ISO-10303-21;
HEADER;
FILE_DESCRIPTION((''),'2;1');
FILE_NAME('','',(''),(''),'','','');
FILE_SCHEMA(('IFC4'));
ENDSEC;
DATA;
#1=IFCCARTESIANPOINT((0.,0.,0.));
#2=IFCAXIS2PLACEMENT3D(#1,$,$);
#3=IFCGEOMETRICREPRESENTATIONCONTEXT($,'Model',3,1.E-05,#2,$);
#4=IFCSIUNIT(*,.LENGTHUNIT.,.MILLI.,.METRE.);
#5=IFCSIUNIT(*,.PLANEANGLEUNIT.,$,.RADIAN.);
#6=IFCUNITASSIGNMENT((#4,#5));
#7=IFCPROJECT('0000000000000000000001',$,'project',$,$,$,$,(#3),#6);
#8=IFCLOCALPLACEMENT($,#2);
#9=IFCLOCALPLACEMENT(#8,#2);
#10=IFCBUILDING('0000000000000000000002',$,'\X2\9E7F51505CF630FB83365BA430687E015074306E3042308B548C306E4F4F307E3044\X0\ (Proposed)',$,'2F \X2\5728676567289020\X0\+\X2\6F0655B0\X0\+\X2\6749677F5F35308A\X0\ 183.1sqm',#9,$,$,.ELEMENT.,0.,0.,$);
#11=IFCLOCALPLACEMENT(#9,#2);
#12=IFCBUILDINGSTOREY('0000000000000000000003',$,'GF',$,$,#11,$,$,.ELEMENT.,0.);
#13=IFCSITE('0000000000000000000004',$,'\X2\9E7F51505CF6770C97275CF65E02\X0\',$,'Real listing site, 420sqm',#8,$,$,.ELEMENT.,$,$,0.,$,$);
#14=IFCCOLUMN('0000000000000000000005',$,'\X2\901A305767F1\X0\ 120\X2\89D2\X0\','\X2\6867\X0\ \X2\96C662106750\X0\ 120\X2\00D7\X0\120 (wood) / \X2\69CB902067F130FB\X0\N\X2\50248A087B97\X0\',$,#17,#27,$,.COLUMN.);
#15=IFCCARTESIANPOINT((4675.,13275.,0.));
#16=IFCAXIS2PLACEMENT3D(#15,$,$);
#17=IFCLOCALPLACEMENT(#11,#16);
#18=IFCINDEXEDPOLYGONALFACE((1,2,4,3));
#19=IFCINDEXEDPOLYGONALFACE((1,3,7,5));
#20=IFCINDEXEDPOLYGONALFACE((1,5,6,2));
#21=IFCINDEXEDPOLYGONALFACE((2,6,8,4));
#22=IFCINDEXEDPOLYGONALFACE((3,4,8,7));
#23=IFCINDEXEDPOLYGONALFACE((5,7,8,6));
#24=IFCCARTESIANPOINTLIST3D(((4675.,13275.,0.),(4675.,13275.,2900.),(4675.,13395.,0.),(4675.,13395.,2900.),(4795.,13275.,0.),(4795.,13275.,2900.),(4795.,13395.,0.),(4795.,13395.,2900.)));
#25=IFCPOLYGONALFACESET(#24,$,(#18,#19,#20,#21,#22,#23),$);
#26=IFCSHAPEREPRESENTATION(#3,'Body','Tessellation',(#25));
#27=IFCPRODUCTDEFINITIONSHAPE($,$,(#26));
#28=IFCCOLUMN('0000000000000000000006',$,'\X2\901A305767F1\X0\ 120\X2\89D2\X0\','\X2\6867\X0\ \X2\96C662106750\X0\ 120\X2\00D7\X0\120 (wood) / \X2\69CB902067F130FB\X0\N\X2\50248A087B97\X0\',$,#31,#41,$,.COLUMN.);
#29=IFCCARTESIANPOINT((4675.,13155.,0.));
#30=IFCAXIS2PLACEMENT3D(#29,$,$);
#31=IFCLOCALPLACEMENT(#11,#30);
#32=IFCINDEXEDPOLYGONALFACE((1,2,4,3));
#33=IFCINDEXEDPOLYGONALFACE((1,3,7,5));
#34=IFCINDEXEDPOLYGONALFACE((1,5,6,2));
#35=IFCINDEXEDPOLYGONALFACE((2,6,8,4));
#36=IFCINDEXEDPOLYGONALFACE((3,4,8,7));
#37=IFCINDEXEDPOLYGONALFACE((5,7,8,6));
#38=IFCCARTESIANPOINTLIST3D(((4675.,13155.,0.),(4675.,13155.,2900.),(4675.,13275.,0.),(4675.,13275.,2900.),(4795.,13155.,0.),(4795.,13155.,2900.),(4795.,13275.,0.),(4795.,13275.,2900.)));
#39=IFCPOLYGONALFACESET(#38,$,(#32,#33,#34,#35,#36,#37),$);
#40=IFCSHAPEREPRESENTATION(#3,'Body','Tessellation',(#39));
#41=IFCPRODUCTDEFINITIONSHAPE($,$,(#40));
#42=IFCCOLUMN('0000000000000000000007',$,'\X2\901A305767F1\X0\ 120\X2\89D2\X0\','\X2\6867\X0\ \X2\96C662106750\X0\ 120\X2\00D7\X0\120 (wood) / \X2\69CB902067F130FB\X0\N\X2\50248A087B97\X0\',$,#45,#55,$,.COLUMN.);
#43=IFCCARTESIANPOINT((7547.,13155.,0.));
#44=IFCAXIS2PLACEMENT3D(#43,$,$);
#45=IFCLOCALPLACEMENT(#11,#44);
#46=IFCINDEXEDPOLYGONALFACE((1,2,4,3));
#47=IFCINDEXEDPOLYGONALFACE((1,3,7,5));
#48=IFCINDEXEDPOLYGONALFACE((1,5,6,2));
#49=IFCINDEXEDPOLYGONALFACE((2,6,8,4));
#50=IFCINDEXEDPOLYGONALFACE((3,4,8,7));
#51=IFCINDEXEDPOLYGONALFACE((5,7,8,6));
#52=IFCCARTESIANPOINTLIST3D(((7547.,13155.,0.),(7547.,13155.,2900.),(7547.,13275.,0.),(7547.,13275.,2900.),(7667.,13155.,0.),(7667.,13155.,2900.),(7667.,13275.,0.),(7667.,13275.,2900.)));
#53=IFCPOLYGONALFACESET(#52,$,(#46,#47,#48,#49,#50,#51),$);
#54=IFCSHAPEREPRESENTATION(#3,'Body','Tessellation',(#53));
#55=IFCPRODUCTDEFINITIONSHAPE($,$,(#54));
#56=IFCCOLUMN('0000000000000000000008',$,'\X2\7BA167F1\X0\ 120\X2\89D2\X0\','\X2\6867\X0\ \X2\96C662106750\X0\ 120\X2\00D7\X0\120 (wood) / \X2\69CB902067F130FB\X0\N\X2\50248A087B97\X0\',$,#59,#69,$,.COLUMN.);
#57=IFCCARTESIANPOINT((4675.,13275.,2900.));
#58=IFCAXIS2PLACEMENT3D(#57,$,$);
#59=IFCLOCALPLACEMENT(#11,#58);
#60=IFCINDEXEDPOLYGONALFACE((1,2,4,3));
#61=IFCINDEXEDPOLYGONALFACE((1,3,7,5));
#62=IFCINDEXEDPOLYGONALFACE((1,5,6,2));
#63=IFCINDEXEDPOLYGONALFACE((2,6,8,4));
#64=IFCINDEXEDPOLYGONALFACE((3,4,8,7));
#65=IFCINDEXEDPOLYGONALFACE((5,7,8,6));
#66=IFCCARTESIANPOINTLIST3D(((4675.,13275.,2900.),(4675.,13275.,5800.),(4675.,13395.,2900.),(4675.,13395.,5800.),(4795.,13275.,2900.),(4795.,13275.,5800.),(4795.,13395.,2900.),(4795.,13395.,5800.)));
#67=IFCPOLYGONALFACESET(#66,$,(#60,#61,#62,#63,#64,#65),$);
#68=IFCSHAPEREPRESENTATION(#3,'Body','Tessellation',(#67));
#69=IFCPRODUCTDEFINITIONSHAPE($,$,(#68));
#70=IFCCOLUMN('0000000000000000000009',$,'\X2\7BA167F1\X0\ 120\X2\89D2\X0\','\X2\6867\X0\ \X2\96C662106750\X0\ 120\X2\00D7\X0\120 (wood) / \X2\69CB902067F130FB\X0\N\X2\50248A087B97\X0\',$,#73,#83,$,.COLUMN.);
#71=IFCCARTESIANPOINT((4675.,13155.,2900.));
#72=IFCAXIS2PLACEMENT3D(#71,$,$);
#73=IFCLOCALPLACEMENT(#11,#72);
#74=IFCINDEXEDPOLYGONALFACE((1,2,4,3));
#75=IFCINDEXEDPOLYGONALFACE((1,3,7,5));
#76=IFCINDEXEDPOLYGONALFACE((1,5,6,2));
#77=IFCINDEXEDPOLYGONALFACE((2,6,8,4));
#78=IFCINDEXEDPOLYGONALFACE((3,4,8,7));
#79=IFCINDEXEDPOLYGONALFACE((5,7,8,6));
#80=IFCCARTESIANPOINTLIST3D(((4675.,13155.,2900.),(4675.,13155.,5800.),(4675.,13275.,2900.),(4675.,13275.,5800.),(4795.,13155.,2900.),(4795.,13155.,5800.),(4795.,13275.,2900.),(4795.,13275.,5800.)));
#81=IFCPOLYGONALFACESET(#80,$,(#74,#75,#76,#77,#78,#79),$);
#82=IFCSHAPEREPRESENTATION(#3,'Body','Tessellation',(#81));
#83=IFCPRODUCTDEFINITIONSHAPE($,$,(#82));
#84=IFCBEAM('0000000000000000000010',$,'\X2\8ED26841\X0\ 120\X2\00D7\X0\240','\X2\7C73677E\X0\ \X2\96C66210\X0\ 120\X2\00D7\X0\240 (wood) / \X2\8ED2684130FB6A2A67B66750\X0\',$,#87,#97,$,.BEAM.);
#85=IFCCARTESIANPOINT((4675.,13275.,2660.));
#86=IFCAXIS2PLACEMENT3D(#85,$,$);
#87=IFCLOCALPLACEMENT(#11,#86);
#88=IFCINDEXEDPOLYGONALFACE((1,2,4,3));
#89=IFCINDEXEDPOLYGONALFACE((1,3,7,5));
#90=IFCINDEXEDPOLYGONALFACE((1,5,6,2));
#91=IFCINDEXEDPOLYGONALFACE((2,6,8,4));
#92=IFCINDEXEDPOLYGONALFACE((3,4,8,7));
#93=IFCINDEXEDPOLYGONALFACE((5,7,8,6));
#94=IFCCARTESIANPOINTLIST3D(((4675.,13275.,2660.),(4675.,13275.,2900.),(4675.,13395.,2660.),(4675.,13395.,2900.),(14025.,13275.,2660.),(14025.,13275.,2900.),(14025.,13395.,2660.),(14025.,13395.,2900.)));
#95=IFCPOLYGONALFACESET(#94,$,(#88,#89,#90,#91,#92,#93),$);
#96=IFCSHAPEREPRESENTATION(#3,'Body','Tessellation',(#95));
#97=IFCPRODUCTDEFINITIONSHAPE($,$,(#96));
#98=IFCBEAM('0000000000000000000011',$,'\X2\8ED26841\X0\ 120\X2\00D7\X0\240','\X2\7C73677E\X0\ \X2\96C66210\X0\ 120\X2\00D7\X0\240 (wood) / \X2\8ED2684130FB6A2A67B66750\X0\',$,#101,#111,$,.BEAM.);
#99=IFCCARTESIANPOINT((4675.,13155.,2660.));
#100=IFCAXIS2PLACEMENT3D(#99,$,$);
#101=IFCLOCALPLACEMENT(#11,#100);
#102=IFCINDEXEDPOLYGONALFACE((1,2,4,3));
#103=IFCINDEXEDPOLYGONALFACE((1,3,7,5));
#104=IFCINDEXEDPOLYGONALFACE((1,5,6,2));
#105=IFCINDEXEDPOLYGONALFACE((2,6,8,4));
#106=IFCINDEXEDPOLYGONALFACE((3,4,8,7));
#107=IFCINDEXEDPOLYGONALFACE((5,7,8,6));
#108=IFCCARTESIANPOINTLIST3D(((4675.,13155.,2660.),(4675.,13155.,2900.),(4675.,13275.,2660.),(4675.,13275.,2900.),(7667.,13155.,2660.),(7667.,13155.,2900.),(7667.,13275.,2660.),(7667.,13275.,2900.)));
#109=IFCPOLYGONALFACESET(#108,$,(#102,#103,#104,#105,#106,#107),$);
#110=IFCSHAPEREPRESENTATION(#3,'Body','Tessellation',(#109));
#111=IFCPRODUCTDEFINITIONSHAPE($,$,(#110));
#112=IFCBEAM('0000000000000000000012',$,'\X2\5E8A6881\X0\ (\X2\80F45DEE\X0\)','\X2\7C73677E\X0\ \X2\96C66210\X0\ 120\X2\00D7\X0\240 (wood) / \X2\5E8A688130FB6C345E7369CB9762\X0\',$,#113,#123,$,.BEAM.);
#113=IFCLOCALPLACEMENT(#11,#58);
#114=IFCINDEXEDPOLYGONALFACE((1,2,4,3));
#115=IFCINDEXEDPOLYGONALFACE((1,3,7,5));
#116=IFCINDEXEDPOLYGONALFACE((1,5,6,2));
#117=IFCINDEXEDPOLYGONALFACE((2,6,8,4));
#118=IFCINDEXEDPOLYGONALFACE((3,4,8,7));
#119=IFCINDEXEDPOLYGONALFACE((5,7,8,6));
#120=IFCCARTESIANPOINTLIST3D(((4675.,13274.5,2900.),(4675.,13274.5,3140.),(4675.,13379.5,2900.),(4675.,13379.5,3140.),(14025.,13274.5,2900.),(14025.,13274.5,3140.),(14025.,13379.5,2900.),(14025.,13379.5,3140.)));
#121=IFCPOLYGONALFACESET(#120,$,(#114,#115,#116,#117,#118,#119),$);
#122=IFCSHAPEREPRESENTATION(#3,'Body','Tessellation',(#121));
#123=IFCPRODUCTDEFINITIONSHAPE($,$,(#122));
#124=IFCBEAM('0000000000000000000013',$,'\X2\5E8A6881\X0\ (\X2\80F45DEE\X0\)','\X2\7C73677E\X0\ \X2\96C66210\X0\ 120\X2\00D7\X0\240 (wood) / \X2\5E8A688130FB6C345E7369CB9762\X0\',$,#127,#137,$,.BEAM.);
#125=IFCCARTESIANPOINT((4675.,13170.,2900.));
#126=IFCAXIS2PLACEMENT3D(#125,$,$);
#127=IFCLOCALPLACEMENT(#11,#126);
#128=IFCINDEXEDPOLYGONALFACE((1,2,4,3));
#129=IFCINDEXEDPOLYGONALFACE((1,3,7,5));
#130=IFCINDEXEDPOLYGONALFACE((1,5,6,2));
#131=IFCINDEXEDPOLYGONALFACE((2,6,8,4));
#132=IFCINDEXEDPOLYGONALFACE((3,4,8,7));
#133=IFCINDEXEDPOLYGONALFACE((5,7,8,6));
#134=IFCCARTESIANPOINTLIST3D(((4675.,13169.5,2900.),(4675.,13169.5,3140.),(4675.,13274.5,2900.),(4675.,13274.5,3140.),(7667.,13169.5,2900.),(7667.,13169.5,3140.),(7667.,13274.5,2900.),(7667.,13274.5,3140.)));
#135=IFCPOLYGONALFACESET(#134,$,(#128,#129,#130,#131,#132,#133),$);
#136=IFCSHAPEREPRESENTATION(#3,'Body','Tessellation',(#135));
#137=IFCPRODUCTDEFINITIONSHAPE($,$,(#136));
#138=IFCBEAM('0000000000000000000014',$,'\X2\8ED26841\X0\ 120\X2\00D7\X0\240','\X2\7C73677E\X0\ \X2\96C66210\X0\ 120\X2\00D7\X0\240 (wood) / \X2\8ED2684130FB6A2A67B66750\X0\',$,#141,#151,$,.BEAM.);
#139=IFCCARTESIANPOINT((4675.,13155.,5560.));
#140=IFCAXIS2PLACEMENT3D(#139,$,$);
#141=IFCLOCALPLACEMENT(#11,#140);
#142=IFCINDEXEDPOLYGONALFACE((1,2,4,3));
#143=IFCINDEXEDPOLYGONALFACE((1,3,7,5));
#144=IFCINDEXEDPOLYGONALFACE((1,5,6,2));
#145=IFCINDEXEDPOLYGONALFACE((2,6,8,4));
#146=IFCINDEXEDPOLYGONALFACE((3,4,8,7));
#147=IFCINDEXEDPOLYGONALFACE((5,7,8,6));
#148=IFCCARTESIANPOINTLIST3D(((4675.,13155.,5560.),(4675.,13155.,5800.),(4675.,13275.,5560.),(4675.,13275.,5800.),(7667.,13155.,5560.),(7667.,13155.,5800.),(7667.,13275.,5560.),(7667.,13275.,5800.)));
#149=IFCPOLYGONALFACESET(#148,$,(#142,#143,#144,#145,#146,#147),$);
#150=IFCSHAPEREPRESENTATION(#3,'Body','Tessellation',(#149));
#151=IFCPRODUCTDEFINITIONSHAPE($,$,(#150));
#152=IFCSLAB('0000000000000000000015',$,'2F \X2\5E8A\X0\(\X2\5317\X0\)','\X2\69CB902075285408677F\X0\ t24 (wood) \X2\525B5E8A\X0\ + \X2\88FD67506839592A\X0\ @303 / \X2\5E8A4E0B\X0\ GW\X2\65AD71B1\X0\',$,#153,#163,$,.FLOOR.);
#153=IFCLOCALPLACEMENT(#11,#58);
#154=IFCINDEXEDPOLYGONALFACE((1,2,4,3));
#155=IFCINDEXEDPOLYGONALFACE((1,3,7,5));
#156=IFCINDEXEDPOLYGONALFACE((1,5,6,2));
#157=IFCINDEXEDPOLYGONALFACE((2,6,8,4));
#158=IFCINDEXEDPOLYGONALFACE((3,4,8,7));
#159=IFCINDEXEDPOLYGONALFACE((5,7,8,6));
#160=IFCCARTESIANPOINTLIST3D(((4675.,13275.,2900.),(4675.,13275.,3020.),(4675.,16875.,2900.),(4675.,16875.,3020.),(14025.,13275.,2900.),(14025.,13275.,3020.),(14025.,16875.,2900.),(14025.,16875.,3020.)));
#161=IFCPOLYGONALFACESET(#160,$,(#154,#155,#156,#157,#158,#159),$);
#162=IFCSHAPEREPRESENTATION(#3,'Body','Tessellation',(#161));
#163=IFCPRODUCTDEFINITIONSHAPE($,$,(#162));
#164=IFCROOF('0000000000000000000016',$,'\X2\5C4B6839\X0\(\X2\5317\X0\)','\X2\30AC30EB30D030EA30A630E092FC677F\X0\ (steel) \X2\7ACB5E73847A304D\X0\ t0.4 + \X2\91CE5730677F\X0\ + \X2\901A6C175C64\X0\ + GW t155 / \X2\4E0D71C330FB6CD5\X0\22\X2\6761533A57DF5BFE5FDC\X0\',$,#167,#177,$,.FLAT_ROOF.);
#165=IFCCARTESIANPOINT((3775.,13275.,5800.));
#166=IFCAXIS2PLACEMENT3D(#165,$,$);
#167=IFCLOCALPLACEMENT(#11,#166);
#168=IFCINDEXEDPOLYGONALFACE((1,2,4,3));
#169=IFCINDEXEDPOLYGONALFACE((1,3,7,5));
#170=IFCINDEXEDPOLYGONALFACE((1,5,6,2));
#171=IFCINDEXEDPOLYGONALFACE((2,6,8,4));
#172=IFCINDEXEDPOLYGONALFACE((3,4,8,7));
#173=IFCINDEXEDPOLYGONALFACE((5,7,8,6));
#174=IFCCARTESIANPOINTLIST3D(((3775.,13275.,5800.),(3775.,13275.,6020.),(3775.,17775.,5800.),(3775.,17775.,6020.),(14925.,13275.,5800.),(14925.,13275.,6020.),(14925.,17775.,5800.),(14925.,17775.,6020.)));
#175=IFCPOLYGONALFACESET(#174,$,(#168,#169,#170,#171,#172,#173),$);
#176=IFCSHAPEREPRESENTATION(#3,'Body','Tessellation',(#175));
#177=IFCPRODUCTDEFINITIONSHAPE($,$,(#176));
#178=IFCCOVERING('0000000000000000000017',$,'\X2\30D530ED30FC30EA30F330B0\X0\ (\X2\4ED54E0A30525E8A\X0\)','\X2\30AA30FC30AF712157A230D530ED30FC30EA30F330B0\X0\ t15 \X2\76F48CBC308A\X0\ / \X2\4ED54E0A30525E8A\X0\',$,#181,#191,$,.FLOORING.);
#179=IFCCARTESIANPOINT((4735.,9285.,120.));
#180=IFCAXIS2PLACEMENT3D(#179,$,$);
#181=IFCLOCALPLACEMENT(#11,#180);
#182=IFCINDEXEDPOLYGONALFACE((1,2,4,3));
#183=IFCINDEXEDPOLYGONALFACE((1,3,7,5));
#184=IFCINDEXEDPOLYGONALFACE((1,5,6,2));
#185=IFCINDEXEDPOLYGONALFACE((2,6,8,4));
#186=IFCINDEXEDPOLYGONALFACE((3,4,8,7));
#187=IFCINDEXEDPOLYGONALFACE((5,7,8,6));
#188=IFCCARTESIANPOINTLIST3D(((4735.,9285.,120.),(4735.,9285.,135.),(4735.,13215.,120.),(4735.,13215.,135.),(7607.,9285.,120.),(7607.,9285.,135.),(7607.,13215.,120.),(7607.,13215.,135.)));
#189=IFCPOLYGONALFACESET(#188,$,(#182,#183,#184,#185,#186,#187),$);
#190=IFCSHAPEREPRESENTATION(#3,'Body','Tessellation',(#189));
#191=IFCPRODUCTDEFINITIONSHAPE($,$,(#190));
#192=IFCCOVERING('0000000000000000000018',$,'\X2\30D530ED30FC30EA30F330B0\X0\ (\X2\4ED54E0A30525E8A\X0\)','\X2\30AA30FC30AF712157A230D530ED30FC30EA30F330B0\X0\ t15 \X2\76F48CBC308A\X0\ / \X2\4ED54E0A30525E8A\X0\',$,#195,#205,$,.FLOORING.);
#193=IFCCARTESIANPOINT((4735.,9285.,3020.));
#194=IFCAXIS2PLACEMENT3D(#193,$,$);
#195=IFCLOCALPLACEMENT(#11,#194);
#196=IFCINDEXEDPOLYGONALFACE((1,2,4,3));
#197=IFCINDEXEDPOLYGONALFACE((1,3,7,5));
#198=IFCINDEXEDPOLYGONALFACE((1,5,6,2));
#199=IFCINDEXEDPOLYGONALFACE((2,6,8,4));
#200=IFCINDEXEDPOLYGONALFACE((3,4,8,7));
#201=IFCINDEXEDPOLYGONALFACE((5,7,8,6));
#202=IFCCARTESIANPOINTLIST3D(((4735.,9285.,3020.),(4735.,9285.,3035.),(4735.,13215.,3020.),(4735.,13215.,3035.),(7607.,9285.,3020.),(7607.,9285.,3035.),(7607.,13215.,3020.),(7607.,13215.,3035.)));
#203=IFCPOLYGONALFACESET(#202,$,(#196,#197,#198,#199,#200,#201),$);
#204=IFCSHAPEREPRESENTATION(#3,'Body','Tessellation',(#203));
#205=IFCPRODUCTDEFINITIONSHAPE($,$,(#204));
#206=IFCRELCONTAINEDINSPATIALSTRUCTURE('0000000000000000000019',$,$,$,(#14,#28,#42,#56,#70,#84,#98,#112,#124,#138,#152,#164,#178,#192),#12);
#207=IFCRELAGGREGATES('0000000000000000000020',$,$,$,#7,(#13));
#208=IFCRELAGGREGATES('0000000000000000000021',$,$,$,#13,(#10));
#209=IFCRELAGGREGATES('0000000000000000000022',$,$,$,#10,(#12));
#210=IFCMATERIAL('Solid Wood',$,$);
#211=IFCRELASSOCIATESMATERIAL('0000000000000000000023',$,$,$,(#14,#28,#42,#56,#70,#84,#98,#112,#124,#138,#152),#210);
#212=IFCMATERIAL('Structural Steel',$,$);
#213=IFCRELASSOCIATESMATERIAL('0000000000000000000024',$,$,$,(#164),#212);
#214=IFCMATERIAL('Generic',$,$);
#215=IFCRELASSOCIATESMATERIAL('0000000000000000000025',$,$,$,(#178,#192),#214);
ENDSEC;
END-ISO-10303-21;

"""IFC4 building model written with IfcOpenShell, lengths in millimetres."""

from ifc_helpers import new_model, si_unit, frame, frame_2d, origin, place, context, project, spatial, rectangle, extrude, material, element, save


model = new_model("IFC4")

# Units and contexts
model_context = context("Model", 3, precision=1e-05, world=origin())
ifc_project = project(units=[si_unit("LENGTHUNIT", "METRE", prefix="MILLI"), si_unit("PLANEANGLEUNIT", "RADIAN")], contexts=[model_context])

# Site, building, storey
site_placement = place(None, origin())
site = spatial("IfcSite", under=ifc_project, at=site_placement, Name="鹿児島県霧島市", ObjectType="Real listing site, 420sqm", CompositionType="ELEMENT", RefElevation=0.0)
building_placement = place(site_placement, origin())
building = spatial("IfcBuilding", under=site, at=building_placement, Name="鹿児島・茶室と縁側のある和の住まい (Proposed)", ObjectType="2F 在来木造+漆喰+杉板張り 183.1sqm", CompositionType="ELEMENT", ElevationOfRefHeight=0.0, ElevationOfTerrain=0.0)
storey_placement = place(building_placement, origin())
storey = spatial("IfcBuildingStorey", under=building, at=storey_placement, Name="GF", CompositionType="ELEMENT", Elevation=0.0)

# Columns
ifc_material_1 = material(Name="Solid Wood")
column_1_placement = place(storey_placement, frame((4675.0, 13275.0, 0.0)))
element("IfcColumn", 1, at=column_1_placement, inside=storey, material=ifc_material_1, Name="通し柱 120角", Description="桧 集成材 120×120 (wood) / 構造柱・N値計算", PredefinedType="COLUMN", context=model_context, shape_type="SweptSolid", body=[
    extrude(rectangle(XDim=120.0, YDim=120.0, at=frame_2d((60.0, 60.0))), frame((4675.0, 13275.0, 0.0)), (0.0, 0.0, 1.0), 2900.0),
])
column_2_placement = place(storey_placement, frame((4675.0, 13155.0, 0.0)))
element("IfcColumn", 2, at=column_2_placement, inside=storey, material=ifc_material_1, Name="通し柱 120角", Description="桧 集成材 120×120 (wood) / 構造柱・N値計算", PredefinedType="COLUMN", context=model_context, shape_type="SweptSolid", body=[
    extrude(rectangle(XDim=120.0, YDim=120.0, at=frame_2d((60.0, 60.0))), frame((4675.0, 13155.0, 0.0)), (0.0, 0.0, 1.0), 2900.0),
])
column_3_placement = place(storey_placement, frame((7547.0, 13155.0, 0.0)))
element("IfcColumn", 3, at=column_3_placement, inside=storey, material=ifc_material_1, Name="通し柱 120角", Description="桧 集成材 120×120 (wood) / 構造柱・N値計算", PredefinedType="COLUMN", context=model_context, shape_type="SweptSolid", body=[
    extrude(rectangle(XDim=120.0, YDim=120.0, at=frame_2d((60.0, 60.0))), frame((7547.0, 13155.0, 0.0)), (0.0, 0.0, 1.0), 2900.0),
])
column_4_placement = place(storey_placement, frame((4675.0, 13275.0, 2900.0)))
element("IfcColumn", 4, at=column_4_placement, inside=storey, material=ifc_material_1, Name="管柱 120角", Description="桧 集成材 120×120 (wood) / 構造柱・N値計算", PredefinedType="COLUMN", context=model_context, shape_type="SweptSolid", body=[
    extrude(rectangle(XDim=120.0, YDim=120.0, at=frame_2d((60.0, 60.0))), frame((4675.0, 13275.0, 2900.0)), (0.0, 0.0, 1.0), 2900.0),
])
column_5_placement = place(storey_placement, frame((4675.0, 13155.0, 2900.0)))
element("IfcColumn", 5, at=column_5_placement, inside=storey, material=ifc_material_1, Name="管柱 120角", Description="桧 集成材 120×120 (wood) / 構造柱・N値計算", PredefinedType="COLUMN", context=model_context, shape_type="SweptSolid", body=[
    extrude(rectangle(XDim=120.0, YDim=120.0, at=frame_2d((60.0, 60.0))), frame((4675.0, 13155.0, 2900.0)), (0.0, 0.0, 1.0), 2900.0),
])

# Beams
beam_1_placement = place(storey_placement, frame((4675.0, 13275.0, 2660.0)))
element("IfcBeam", 6, at=beam_1_placement, inside=storey, material=ifc_material_1, Name="軒桁 120×240", Description="米松 集成 120×240 (wood) / 軒桁・横架材", PredefinedType="BEAM", context=model_context, shape_type="SweptSolid", body=[
    extrude(rectangle(XDim=9350.0, YDim=120.0, at=frame_2d((4675.0, 60.0))), frame((4675.0, 13275.0, 2660.0)), (0.0, 0.0, 1.0), 240.0),
])
beam_2_placement = place(storey_placement, frame((4675.0, 13155.0, 2660.0)))
element("IfcBeam", 7, at=beam_2_placement, inside=storey, material=ifc_material_1, Name="軒桁 120×240", Description="米松 集成 120×240 (wood) / 軒桁・横架材", PredefinedType="BEAM", context=model_context, shape_type="SweptSolid", body=[
    extrude(rectangle(XDim=2992.0, YDim=120.0, at=frame_2d((1496.0, 60.0))), frame((4675.0, 13155.0, 2660.0)), (0.0, 0.0, 1.0), 240.0),
])
beam_3_placement = place(storey_placement, frame((4675.0, 13275.0, 2900.0)))
element("IfcBeam", 8, at=beam_3_placement, inside=storey, material=ifc_material_1, Name="床梁 (胴差)", Description="米松 集成 120×240 (wood) / 床梁・水平構面", PredefinedType="BEAM", context=model_context, shape_type="SweptSolid", body=[
    extrude(rectangle(XDim=9350.0, YDim=105.0, at=frame_2d((4675.0, 52.0))), frame((4675.0, 13275.0, 2900.0)), (0.0, 0.0, 1.0), 240.0),
])
beam_4_placement = place(storey_placement, frame((4675.0, 13170.0, 2900.0)))
element("IfcBeam", 9, at=beam_4_placement, inside=storey, material=ifc_material_1, Name="床梁 (胴差)", Description="米松 集成 120×240 (wood) / 床梁・水平構面", PredefinedType="BEAM", context=model_context, shape_type="SweptSolid", body=[
    extrude(rectangle(XDim=2992.0, YDim=105.0, at=frame_2d((1496.0, 52.0))), frame((4675.0, 13170.0, 2900.0)), (0.0, 0.0, 1.0), 240.0),
])
beam_5_placement = place(storey_placement, frame((4675.0, 13155.0, 5560.0)))
element("IfcBeam", 10, at=beam_5_placement, inside=storey, material=ifc_material_1, Name="軒桁 120×240", Description="米松 集成 120×240 (wood) / 軒桁・横架材", PredefinedType="BEAM", context=model_context, shape_type="SweptSolid", body=[
    extrude(rectangle(XDim=2992.0, YDim=120.0, at=frame_2d((1496.0, 60.0))), frame((4675.0, 13155.0, 5560.0)), (0.0, 0.0, 1.0), 240.0),
])

# Slab
slab_1_placement = place(storey_placement, frame((4675.0, 13275.0, 2900.0)))
element("IfcSlab", 11, at=slab_1_placement, inside=storey, material=ifc_material_1, Name="2F 床(北)", Description="構造用合板 t24 (wood) 剛床 + 製材根太 @303 / 床下 GW断熱", PredefinedType="FLOOR", context=model_context, shape_type="SweptSolid", body=[
    extrude(rectangle(XDim=9350.0, YDim=3600.0, at=frame_2d((4675.0, 1800.0))), frame((4675.0, 13275.0, 2900.0)), (0.0, 0.0, 1.0), 120.0),
])

# Roof
ifc_material_2 = material(Name="Structural Steel")
for number, where, name in (
    (12, (3775.0, 13275.0, 5800.0), "屋根(北)"),
):
    element("IfcRoof", number, at=place(storey_placement, frame(where)), inside=storey, material=ifc_material_2, Name=name, Description="ガルバリウム鋼板 (steel) 立平葺き t0.4 + 野地板 + 通気層 + GW t155 / 不燃・法22条区域対応", PredefinedType="FLAT_ROOF", context=model_context, shape_type="SweptSolid", body=[
        extrude(rectangle(XDim=11150.0, YDim=4500.0, at=frame_2d((5575.0, 2250.0))), frame((3775.0, 13275.0, 5800.0)), (0.0, 0.0, 1.0), 220.0),
    ])

# Coverings
ifc_material_3 = material(Name="Generic")
covering_1_placement = place(storey_placement, frame((4735.0, 9285.0, 120.0)))
element("IfcCovering", 13, at=covering_1_placement, inside=storey, material=ifc_material_3, Name="フローリング (仕上げ床)", Description="オーク無垢フローリング t15 直貼り / 仕上げ床", PredefinedType="FLOORING", context=model_context, shape_type="SweptSolid", body=[
    extrude(rectangle(XDim=2872.0, YDim=3930.0, at=frame_2d((1436.0, 1965.0))), frame((4735.0, 9285.0, 120.0)), (0.0, 0.0, 1.0), 15.0),
])
covering_2_placement = place(storey_placement, frame((4735.0, 9285.0, 3020.0)))
element("IfcCovering", 14, at=covering_2_placement, inside=storey, material=ifc_material_3, Name="フローリング (仕上げ床)", Description="オーク無垢フローリング t15 直貼り / 仕上げ床", PredefinedType="FLOORING", context=model_context, shape_type="SweptSolid", body=[
    extrude(rectangle(XDim=2872.0, YDim=3930.0, at=frame_2d((1436.0, 1965.0))), frame((4735.0, 9285.0, 3020.0)), (0.0, 0.0, 1.0), 15.0),
])

save(model, "model.ifc")
